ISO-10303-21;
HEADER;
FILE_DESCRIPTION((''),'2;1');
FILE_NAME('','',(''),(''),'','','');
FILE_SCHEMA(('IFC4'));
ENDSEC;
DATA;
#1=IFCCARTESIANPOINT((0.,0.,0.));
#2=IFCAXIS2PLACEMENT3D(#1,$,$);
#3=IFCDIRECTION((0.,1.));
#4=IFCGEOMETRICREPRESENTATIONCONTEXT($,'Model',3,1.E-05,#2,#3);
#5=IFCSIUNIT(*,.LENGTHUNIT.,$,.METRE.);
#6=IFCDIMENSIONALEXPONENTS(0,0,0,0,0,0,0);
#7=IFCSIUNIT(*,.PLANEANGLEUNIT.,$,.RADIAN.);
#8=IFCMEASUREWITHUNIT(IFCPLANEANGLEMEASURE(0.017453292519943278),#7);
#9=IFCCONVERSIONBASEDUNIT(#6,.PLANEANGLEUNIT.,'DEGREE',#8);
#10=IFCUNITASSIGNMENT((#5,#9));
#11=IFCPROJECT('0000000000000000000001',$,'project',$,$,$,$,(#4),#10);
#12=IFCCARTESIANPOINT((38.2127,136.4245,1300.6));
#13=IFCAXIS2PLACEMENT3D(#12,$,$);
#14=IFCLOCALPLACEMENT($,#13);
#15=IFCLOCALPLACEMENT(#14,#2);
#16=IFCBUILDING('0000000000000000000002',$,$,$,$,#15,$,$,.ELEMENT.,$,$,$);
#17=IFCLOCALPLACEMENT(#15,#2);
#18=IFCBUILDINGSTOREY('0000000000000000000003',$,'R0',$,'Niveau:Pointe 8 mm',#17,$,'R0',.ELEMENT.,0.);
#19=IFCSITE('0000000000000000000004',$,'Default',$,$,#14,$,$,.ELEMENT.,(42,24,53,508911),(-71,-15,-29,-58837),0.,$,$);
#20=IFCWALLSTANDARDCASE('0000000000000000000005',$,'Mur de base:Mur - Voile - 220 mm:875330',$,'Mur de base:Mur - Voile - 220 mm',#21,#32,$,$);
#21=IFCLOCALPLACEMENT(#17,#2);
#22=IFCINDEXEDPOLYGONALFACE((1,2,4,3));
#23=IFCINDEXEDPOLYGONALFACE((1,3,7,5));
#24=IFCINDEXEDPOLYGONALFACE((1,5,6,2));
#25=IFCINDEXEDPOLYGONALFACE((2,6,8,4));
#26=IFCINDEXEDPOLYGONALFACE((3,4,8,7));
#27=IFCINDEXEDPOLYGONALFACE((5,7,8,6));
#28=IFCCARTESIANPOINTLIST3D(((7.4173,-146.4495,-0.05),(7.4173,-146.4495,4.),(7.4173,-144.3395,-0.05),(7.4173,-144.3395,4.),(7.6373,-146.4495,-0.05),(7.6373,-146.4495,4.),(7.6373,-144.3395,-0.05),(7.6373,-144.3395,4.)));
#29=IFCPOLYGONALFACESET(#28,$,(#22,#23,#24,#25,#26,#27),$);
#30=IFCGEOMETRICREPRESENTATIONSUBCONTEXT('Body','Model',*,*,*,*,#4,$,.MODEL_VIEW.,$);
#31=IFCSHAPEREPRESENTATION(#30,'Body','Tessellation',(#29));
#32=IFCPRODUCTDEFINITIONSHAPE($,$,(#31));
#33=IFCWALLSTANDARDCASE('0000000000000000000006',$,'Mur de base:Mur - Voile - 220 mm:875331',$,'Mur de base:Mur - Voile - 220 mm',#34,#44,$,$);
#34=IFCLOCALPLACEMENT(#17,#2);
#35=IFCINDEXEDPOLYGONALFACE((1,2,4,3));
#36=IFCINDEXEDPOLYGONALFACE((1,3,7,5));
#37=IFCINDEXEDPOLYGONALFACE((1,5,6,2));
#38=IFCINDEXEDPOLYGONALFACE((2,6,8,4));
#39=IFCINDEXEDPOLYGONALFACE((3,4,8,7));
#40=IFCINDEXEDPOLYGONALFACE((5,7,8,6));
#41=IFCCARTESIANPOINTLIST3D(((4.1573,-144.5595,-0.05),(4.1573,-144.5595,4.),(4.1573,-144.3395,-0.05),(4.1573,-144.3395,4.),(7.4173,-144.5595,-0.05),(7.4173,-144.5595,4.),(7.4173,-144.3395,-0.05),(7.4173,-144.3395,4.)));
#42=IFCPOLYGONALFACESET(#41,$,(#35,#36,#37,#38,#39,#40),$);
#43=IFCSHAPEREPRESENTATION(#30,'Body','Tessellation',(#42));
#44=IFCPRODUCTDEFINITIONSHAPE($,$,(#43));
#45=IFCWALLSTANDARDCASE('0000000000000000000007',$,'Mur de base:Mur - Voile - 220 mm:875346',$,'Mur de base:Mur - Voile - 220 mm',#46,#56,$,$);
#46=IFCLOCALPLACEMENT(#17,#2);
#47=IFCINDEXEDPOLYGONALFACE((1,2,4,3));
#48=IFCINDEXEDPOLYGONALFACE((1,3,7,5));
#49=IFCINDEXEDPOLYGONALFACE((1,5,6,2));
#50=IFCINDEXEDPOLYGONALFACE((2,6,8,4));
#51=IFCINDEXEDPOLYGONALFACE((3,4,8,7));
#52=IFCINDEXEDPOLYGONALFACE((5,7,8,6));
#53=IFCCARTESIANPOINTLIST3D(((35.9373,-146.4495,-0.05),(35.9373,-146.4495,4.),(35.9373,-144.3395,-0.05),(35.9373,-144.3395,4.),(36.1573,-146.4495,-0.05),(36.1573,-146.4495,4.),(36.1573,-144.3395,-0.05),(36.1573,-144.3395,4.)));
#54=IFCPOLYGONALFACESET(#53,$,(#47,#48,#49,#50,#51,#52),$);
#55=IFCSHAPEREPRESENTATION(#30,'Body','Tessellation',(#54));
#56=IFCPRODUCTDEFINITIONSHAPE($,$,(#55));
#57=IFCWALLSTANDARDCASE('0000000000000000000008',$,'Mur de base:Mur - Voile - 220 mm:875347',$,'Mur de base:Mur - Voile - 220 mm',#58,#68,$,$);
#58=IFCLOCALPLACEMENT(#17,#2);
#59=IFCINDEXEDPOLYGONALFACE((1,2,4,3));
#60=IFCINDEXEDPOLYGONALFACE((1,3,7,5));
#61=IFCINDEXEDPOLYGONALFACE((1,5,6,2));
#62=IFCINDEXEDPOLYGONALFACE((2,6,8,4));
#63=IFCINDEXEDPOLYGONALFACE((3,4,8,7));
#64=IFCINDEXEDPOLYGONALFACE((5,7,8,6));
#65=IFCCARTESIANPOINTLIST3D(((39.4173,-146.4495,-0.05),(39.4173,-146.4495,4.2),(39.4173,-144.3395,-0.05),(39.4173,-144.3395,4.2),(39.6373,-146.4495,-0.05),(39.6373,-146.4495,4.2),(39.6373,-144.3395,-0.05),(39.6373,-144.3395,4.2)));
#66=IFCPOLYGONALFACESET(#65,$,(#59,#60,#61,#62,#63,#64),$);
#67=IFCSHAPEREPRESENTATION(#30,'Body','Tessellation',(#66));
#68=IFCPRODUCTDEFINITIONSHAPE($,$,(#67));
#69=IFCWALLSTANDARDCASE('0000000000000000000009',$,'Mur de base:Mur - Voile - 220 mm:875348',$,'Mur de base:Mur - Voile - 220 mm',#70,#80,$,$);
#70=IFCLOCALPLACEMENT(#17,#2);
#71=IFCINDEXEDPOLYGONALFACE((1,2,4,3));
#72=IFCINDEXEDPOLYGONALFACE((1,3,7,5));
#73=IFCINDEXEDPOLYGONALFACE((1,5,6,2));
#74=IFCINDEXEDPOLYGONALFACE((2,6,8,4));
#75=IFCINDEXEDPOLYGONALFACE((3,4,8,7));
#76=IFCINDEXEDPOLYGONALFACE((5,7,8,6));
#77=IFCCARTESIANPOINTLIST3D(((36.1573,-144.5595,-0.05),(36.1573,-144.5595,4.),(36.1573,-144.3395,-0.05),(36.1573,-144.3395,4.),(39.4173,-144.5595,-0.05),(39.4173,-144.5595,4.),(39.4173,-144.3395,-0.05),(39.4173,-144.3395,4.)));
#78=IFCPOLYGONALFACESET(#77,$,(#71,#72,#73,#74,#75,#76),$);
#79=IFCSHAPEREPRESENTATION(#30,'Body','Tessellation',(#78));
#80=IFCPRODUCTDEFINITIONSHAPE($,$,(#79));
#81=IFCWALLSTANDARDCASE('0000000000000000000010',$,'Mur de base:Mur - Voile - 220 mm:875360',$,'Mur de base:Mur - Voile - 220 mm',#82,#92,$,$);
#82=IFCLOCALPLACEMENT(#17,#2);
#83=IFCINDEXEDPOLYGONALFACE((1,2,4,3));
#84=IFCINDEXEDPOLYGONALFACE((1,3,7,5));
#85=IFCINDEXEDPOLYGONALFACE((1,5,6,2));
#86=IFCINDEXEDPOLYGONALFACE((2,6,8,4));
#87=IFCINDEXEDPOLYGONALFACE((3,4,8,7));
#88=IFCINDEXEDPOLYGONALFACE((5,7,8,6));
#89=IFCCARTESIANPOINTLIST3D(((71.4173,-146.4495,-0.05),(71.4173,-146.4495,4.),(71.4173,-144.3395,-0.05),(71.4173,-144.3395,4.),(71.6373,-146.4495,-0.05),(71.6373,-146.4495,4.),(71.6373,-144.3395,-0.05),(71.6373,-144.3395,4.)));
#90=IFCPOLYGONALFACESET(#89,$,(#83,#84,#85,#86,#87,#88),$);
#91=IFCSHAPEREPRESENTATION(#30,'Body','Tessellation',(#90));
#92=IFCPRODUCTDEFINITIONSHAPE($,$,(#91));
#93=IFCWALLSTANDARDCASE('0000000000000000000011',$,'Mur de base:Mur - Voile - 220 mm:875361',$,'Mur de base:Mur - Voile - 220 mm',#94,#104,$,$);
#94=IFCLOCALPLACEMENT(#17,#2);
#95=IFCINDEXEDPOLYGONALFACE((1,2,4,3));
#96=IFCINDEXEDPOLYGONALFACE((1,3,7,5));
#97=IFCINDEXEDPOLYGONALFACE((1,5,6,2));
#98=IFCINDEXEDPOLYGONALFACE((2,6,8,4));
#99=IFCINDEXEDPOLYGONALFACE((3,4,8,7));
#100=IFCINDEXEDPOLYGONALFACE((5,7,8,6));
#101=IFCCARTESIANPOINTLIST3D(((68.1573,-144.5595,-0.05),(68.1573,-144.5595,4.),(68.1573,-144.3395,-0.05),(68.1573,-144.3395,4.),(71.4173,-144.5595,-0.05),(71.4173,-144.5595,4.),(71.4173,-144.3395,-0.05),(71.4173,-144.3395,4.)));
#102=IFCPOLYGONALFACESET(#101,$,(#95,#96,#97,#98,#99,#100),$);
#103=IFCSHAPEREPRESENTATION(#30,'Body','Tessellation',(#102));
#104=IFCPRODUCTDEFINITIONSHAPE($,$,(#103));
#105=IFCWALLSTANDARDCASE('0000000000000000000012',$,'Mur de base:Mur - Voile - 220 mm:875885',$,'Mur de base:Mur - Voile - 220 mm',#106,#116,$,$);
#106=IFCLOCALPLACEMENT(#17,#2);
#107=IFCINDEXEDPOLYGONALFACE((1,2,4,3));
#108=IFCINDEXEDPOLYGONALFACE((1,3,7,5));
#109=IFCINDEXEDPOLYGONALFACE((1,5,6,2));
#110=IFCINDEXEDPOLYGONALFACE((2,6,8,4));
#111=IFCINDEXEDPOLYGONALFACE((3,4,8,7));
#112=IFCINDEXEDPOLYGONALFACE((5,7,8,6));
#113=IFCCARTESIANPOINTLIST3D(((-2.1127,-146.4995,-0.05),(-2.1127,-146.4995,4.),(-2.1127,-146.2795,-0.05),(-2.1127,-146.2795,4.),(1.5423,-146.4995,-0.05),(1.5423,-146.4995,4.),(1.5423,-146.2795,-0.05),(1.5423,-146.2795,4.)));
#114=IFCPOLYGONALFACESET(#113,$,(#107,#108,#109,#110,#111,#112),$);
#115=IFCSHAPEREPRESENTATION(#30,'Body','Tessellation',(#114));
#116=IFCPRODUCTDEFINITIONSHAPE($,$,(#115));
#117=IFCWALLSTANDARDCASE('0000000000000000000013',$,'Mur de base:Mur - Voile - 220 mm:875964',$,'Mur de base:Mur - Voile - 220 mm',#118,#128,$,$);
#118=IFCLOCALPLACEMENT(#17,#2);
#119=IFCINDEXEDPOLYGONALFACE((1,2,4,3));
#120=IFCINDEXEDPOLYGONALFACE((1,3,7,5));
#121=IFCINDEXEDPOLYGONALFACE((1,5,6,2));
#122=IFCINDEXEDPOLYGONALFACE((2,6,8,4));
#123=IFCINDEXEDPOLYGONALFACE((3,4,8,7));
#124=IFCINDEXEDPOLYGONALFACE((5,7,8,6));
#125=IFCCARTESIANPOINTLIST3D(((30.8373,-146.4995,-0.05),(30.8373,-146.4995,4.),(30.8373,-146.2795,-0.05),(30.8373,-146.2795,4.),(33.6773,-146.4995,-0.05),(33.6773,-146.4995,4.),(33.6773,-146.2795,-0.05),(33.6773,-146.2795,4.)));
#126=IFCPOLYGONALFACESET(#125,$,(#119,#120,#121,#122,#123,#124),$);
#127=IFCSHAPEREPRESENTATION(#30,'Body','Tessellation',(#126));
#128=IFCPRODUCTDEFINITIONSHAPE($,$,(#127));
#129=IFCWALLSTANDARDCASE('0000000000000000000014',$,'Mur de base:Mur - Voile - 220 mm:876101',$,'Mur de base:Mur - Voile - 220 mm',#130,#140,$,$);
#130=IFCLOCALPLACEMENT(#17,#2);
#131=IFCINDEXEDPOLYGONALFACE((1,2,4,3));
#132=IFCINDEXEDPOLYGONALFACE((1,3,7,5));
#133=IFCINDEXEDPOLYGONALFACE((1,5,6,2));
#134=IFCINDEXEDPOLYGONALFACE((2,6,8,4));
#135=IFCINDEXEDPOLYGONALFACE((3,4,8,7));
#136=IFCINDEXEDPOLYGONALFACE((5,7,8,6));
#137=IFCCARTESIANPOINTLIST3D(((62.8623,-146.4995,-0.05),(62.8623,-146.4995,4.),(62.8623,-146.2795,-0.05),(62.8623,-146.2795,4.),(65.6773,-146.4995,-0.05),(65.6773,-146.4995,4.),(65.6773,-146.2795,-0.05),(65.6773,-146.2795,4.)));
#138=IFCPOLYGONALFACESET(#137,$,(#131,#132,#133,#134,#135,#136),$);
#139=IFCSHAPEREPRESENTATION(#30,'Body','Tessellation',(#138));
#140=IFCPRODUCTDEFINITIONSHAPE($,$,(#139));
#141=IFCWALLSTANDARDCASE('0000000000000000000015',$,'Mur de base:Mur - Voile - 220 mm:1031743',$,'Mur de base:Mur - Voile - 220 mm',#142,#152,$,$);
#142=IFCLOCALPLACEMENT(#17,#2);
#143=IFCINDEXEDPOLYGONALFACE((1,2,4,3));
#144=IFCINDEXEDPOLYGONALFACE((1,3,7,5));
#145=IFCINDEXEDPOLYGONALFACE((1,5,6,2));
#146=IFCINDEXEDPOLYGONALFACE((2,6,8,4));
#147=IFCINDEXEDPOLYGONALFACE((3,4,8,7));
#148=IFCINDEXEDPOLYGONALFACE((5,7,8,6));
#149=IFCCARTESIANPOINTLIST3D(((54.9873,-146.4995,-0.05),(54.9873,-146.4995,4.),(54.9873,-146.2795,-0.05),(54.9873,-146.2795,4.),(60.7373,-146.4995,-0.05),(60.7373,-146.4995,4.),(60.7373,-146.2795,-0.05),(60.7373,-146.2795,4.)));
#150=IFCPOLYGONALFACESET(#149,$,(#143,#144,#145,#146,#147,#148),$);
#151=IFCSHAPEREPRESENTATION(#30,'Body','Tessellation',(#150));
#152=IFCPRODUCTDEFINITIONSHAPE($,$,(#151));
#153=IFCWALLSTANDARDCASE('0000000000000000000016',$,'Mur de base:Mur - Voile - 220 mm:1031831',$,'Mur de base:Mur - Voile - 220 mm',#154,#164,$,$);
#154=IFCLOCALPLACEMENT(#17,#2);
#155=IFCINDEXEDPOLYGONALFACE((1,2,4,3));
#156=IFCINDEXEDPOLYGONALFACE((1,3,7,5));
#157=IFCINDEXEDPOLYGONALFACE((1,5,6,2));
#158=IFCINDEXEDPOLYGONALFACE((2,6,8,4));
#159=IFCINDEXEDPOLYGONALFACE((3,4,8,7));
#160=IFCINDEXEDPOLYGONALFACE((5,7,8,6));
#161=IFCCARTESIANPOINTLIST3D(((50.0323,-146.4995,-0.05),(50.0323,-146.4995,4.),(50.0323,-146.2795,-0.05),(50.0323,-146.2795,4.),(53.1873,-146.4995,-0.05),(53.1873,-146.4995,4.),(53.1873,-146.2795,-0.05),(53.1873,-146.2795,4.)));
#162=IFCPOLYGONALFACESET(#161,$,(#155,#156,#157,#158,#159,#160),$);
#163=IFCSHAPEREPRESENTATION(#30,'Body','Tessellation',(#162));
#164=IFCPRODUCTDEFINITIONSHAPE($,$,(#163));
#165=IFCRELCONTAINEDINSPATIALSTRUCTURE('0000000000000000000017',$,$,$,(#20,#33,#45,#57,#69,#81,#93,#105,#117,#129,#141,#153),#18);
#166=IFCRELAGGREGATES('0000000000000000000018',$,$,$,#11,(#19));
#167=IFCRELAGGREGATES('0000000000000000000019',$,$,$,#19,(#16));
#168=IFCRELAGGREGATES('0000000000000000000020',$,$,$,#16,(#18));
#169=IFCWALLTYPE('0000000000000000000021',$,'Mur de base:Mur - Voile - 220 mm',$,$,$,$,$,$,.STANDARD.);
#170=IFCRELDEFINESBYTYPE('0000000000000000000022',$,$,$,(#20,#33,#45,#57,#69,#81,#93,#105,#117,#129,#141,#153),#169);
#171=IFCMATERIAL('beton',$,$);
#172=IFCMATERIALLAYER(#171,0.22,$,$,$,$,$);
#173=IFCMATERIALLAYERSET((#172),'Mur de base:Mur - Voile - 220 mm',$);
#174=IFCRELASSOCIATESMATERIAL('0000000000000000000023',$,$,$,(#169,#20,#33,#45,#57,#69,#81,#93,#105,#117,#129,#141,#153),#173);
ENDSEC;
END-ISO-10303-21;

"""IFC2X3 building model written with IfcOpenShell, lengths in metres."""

from ifc_helpers import new_model, entity, si_unit, converted_unit, direction, frame, frame_2d, origin, place, context, subcontext, project, spatial, polyline, rectangle, extrude, clip, bounded_halfspace, material, layer, layer_set, layer_usage, type_object, element, save


model = new_model("IFC2X3")

# Units and contexts
model_context = context("Model", 3, precision=1e-05, world=origin(), true_north=direction((0.0, 1.0)))
body_context = subcontext(model_context, "Body", "Model", "MODEL_VIEW")
ifc_project = project(units=[si_unit("LENGTHUNIT", "METRE"), converted_unit("PLANEANGLEUNIT", "DEGREE", entity("IfcPlaneAngleMeasure", 0.017453292519943278), si_unit("PLANEANGLEUNIT", "RADIAN"), dimensions=[0, 0, 0, 0, 0, 0, 0])], contexts=[model_context])

# Site, building, storey
site_placement = place(None, frame((38.2127, 136.4245, 1300.6)))
site = spatial("IfcSite", under=ifc_project, at=site_placement, Name="Default", CompositionType="ELEMENT", RefLatitude=(42, 24, 53, 508911), RefLongitude=(-71, -15, -29, -58837), RefElevation=0.0)
building_placement = place(site_placement, origin())
building = spatial("IfcBuilding", under=site, at=building_placement, CompositionType="ELEMENT")
storey_placement = place(building_placement, origin())
storey = spatial("IfcBuildingStorey", under=building, at=storey_placement, Name="R0", ObjectType="Niveau:Pointe 8 mm", LongName="R0", CompositionType="ELEMENT", Elevation=0.0)

# Walls
ifc_material_1 = material(Name="beton")
ifc_layer = layer(ifc_material_1, 0.22)
ifc_layer_set = layer_set([ifc_layer], Name="Mur de base:Mur - Voile - 220 mm")
wall_type = type_object("IfcWallType", Name="Mur de base:Mur - Voile - 220 mm", PredefinedType="STANDARD", material=ifc_layer_set)
ifc_layer_usage_1 = layer_usage(ifc_layer_set, "AXIS2", "POSITIVE", -0.11)
wall_1_placement = place(storey_placement, frame((7.5273, -146.4495, -0.05), z_axis=(0.0, 0.0, 1.0), x_axis=(0.0, 1.0, 0.0)))
element("IfcWallStandardCase", 1, at=wall_1_placement, inside=storey, type_object=wall_type, material=ifc_layer_usage_1, Name="Mur de base:Mur - Voile - 220 mm:875330", ObjectType="Mur de base:Mur - Voile - 220 mm", context=body_context, shape_type="SweptSolid", body=[
    extrude(rectangle(XDim=2.11, YDim=0.22, at=frame_2d((1.055, 0.0), x_axis=(-1.0, 0.0))), origin(), (0.0, 0.0, 1.0), 4.05),
])
ifc_layer_usage_2 = layer_usage(ifc_layer_set, "AXIS2", "POSITIVE", -0.11)
wall_2_placement = place(storey_placement, frame((7.4173, -144.4495, -0.05), z_axis=(0.0, 0.0, 1.0), x_axis=(-1.0, 0.0, 0.0)))
element("IfcWallStandardCase", 2, at=wall_2_placement, inside=storey, type_object=wall_type, material=ifc_layer_usage_2, Name="Mur de base:Mur - Voile - 220 mm:875331", ObjectType="Mur de base:Mur - Voile - 220 mm", context=body_context, shape_type="SweptSolid", body=[
    extrude(rectangle(XDim=3.26, YDim=0.22, at=frame_2d((1.63, 0.0), x_axis=(-1.0, 0.0))), origin(), (0.0, 0.0, 1.0), 4.05),
])
ifc_layer_usage_3 = layer_usage(ifc_layer_set, "AXIS2", "NEGATIVE", 0.11)
wall_3_placement = place(storey_placement, frame((36.0473, -144.3395, -0.05), z_axis=(0.0, 0.0, 1.0), x_axis=(0.0, -1.0, 0.0)))
element("IfcWallStandardCase", 3, at=wall_3_placement, inside=storey, type_object=wall_type, material=ifc_layer_usage_3, Name="Mur de base:Mur - Voile - 220 mm:875346", ObjectType="Mur de base:Mur - Voile - 220 mm", context=body_context, shape_type="SweptSolid", body=[
    extrude(rectangle(XDim=2.11, YDim=0.22, at=frame_2d((1.055, 0.0), x_axis=(-1.0, 0.0))), origin(), (0.0, 0.0, 1.0), 4.05),
])
ifc_layer_usage_4 = layer_usage(ifc_layer_set, "AXIS2", "POSITIVE", -0.11)
wall_4_placement = place(storey_placement, frame((39.5273, -146.4495, -0.05), z_axis=(0.0, 0.0, 1.0), x_axis=(0.0, 1.0, 0.0)))
element("IfcWallStandardCase", 4, at=wall_4_placement, inside=storey, type_object=wall_type, material=ifc_layer_usage_4, Name="Mur de base:Mur - Voile - 220 mm:875347", ObjectType="Mur de base:Mur - Voile - 220 mm", context=body_context, shape_type="SweptSolid", body=[
    extrude(rectangle(XDim=2.11, YDim=0.22, at=frame_2d((1.055, 0.0), x_axis=(-1.0, 0.0))), origin(), (0.0, 0.0, 1.0), 4.25),
])
ifc_layer_usage_5 = layer_usage(ifc_layer_set, "AXIS2", "NEGATIVE", 0.11)
wall_5_placement = place(storey_placement, frame((39.4173, -144.4495, -0.05), z_axis=(0.0, 0.0, 1.0), x_axis=(-1.0, 0.0, 0.0)))
element("IfcWallStandardCase", 5, at=wall_5_placement, inside=storey, type_object=wall_type, material=ifc_layer_usage_5, Name="Mur de base:Mur - Voile - 220 mm:875348", ObjectType="Mur de base:Mur - Voile - 220 mm", context=body_context, shape_type="SweptSolid", body=[
    extrude(rectangle(XDim=3.26, YDim=0.22, at=frame_2d((1.63, 0.0), x_axis=(-1.0, 0.0))), origin(), (0.0, 0.0, 1.0), 4.05),
])
ifc_layer_usage_6 = layer_usage(ifc_layer_set, "AXIS2", "NEGATIVE", 0.11)
wall_6_placement = place(storey_placement, frame((71.5273, -146.4495, -0.05), z_axis=(0.0, 0.0, 1.0), x_axis=(0.0, 1.0, 0.0)))
element("IfcWallStandardCase", 6, at=wall_6_placement, inside=storey, type_object=wall_type, material=ifc_layer_usage_6, Name="Mur de base:Mur - Voile - 220 mm:875360", ObjectType="Mur de base:Mur - Voile - 220 mm", context=body_context, shape_type="SweptSolid", body=[
    extrude(rectangle(XDim=2.11, YDim=0.22, at=frame_2d((1.055, 0.0), x_axis=(-1.0, 0.0))), origin(), (0.0, 0.0, 1.0), 4.05),
])
ifc_layer_usage_7 = layer_usage(ifc_layer_set, "AXIS2", "NEGATIVE", 0.11)
wall_7_placement = place(storey_placement, frame((71.4173, -144.4495, -0.05), z_axis=(0.0, 0.0, 1.0), x_axis=(-1.0, 0.0, 0.0)))
element("IfcWallStandardCase", 7, at=wall_7_placement, inside=storey, type_object=wall_type, material=ifc_layer_usage_7, Name="Mur de base:Mur - Voile - 220 mm:875361", ObjectType="Mur de base:Mur - Voile - 220 mm", context=body_context, shape_type="SweptSolid", body=[
    extrude(rectangle(XDim=3.26, YDim=0.22, at=frame_2d((1.63, 0.0), x_axis=(-1.0, 0.0))), origin(), (0.0, 0.0, 1.0), 4.05),
])
ifc_layer_usage_8 = layer_usage(ifc_layer_set, "AXIS2", "NEGATIVE", 0.11)
wall_8_placement = place(storey_placement, frame((1.5423, -146.3895, -0.05), z_axis=(0.0, 0.0, 1.0), x_axis=(-1.0, 0.0, 0.0)))
element("IfcWallStandardCase", 8, at=wall_8_placement, inside=storey, type_object=wall_type, material=ifc_layer_usage_8, Name="Mur de base:Mur - Voile - 220 mm:875885", ObjectType="Mur de base:Mur - Voile - 220 mm", context=body_context, shape_type="Clipping", body=[
    clip(extrude(rectangle(XDim=3.655, YDim=0.22, at=frame_2d((1.8275, 0.0), x_axis=(-1.0, 0.0))), origin(), (0.0, 0.0, 1.0), 4.05), bounded_halfspace(frame((0.0, -0.11, 4.05), z_axis=(0.0, 0.0, -1.0), x_axis=(0.0, -1.0, 0.0)), True, frame((0.0, -0.11, 4.05)), polyline([(0.0, 0.0), (0.13, 0.0), (3.655, 0.0), (3.655, 0.22), (0.13, 0.22), (0.0, 0.22), (0.0, 0.0)]))),
])
ifc_layer_usage_9 = layer_usage(ifc_layer_set, "AXIS2", "NEGATIVE", 0.11)
wall_9_placement = place(storey_placement, frame((33.6773, -146.3895, -0.05), z_axis=(0.0, 0.0, 1.0), x_axis=(-1.0, 0.0, 0.0)))
element("IfcWallStandardCase", 9, at=wall_9_placement, inside=storey, type_object=wall_type, material=ifc_layer_usage_9, Name="Mur de base:Mur - Voile - 220 mm:875964", ObjectType="Mur de base:Mur - Voile - 220 mm", context=body_context, shape_type="Clipping", body=[
    clip(extrude(rectangle(XDim=2.84, YDim=0.22, at=frame_2d((1.42, 0.0), x_axis=(-1.0, 0.0))), origin(), (0.0, 0.0, 1.0), 4.05), bounded_halfspace(frame((0.0, -0.11, 4.05), z_axis=(0.0, 0.0, -1.0), x_axis=(0.0, -1.0, 0.0)), True, frame((0.0, -0.11, 4.05)), polyline([(0.0, 0.0), (2.84, 0.0), (2.84, 0.22), (0.0, 0.22), (0.0, 0.0)]))),
])
ifc_layer_usage_10 = layer_usage(ifc_layer_set, "AXIS2", "NEGATIVE", 0.11)
wall_10_placement = place(storey_placement, frame((65.6773, -146.3895, -0.05), z_axis=(0.0, 0.0, 1.0), x_axis=(-1.0, 0.0, 0.0)))
element("IfcWallStandardCase", 10, at=wall_10_placement, inside=storey, type_object=wall_type, material=ifc_layer_usage_10, Name="Mur de base:Mur - Voile - 220 mm:876101", ObjectType="Mur de base:Mur - Voile - 220 mm", context=body_context, shape_type="Clipping", body=[
    clip(extrude(rectangle(XDim=2.815, YDim=0.22, at=frame_2d((1.4075, 0.0), x_axis=(-1.0, 0.0))), origin(), (0.0, 0.0, 1.0), 4.05), bounded_halfspace(frame((0.0, -0.11, 4.05), z_axis=(0.0, 0.0, -1.0), x_axis=(0.0, -1.0, 0.0)), True, frame((0.0, -0.11, 4.05)), polyline([(0.0, 0.0), (2.815, 0.0), (2.815, 0.22), (0.0, 0.22), (0.0, 0.0)]))),
])
ifc_layer_usage_11 = layer_usage(ifc_layer_set, "AXIS2", "NEGATIVE", 0.11)
wall_11_placement = place(storey_placement, frame((60.7373, -146.3895, -0.05), z_axis=(0.0, 0.0, 1.0), x_axis=(-1.0, 0.0, 0.0)))
element("IfcWallStandardCase", 11, at=wall_11_placement, inside=storey, type_object=wall_type, material=ifc_layer_usage_11, Name="Mur de base:Mur - Voile - 220 mm:1031743", ObjectType="Mur de base:Mur - Voile - 220 mm", context=body_context, shape_type="Clipping", body=[
    clip(extrude(rectangle(XDim=5.75, YDim=0.22, at=frame_2d((2.875, 0.0), x_axis=(-1.0, 0.0))), origin(), (0.0, 0.0, 1.0), 4.05), bounded_halfspace(frame((0.0, -0.11, 4.05), z_axis=(0.0, 0.0, -1.0), x_axis=(0.0, -1.0, 0.0)), True, frame((0.0, -0.11, 4.05)), polyline([(0.0, 0.0), (3.14, 0.0), (5.75, 0.0), (5.75, 0.22), (3.14, 0.22), (0.0, 0.22), (0.0, 0.0)]))),
])
ifc_layer_usage_12 = layer_usage(ifc_layer_set, "AXIS2", "NEGATIVE", 0.11)
wall_12_placement = place(storey_placement, frame((53.1873, -146.3895, -0.05), z_axis=(0.0, 0.0, 1.0), x_axis=(-1.0, 0.0, 0.0)))
element("IfcWallStandardCase", 12, at=wall_12_placement, inside=storey, type_object=wall_type, material=ifc_layer_usage_12, Name="Mur de base:Mur - Voile - 220 mm:1031831", ObjectType="Mur de base:Mur - Voile - 220 mm", context=body_context, shape_type="Clipping", body=[
    clip(extrude(rectangle(XDim=3.155, YDim=0.22, at=frame_2d((1.5775, 0.0), x_axis=(-1.0, 0.0))), origin(), (0.0, 0.0, 1.0), 4.05), bounded_halfspace(frame((0.0, -0.11, 4.05), z_axis=(0.0, 0.0, -1.0), x_axis=(0.0, -1.0, 0.0)), True, frame((0.0, -0.11, 4.05)), polyline([(0.0, 0.0), (3.155, 0.0), (3.155, 0.22), (0.0, 0.22), (0.0, 0.0)]))),
])

save(model, "model.ifc")
